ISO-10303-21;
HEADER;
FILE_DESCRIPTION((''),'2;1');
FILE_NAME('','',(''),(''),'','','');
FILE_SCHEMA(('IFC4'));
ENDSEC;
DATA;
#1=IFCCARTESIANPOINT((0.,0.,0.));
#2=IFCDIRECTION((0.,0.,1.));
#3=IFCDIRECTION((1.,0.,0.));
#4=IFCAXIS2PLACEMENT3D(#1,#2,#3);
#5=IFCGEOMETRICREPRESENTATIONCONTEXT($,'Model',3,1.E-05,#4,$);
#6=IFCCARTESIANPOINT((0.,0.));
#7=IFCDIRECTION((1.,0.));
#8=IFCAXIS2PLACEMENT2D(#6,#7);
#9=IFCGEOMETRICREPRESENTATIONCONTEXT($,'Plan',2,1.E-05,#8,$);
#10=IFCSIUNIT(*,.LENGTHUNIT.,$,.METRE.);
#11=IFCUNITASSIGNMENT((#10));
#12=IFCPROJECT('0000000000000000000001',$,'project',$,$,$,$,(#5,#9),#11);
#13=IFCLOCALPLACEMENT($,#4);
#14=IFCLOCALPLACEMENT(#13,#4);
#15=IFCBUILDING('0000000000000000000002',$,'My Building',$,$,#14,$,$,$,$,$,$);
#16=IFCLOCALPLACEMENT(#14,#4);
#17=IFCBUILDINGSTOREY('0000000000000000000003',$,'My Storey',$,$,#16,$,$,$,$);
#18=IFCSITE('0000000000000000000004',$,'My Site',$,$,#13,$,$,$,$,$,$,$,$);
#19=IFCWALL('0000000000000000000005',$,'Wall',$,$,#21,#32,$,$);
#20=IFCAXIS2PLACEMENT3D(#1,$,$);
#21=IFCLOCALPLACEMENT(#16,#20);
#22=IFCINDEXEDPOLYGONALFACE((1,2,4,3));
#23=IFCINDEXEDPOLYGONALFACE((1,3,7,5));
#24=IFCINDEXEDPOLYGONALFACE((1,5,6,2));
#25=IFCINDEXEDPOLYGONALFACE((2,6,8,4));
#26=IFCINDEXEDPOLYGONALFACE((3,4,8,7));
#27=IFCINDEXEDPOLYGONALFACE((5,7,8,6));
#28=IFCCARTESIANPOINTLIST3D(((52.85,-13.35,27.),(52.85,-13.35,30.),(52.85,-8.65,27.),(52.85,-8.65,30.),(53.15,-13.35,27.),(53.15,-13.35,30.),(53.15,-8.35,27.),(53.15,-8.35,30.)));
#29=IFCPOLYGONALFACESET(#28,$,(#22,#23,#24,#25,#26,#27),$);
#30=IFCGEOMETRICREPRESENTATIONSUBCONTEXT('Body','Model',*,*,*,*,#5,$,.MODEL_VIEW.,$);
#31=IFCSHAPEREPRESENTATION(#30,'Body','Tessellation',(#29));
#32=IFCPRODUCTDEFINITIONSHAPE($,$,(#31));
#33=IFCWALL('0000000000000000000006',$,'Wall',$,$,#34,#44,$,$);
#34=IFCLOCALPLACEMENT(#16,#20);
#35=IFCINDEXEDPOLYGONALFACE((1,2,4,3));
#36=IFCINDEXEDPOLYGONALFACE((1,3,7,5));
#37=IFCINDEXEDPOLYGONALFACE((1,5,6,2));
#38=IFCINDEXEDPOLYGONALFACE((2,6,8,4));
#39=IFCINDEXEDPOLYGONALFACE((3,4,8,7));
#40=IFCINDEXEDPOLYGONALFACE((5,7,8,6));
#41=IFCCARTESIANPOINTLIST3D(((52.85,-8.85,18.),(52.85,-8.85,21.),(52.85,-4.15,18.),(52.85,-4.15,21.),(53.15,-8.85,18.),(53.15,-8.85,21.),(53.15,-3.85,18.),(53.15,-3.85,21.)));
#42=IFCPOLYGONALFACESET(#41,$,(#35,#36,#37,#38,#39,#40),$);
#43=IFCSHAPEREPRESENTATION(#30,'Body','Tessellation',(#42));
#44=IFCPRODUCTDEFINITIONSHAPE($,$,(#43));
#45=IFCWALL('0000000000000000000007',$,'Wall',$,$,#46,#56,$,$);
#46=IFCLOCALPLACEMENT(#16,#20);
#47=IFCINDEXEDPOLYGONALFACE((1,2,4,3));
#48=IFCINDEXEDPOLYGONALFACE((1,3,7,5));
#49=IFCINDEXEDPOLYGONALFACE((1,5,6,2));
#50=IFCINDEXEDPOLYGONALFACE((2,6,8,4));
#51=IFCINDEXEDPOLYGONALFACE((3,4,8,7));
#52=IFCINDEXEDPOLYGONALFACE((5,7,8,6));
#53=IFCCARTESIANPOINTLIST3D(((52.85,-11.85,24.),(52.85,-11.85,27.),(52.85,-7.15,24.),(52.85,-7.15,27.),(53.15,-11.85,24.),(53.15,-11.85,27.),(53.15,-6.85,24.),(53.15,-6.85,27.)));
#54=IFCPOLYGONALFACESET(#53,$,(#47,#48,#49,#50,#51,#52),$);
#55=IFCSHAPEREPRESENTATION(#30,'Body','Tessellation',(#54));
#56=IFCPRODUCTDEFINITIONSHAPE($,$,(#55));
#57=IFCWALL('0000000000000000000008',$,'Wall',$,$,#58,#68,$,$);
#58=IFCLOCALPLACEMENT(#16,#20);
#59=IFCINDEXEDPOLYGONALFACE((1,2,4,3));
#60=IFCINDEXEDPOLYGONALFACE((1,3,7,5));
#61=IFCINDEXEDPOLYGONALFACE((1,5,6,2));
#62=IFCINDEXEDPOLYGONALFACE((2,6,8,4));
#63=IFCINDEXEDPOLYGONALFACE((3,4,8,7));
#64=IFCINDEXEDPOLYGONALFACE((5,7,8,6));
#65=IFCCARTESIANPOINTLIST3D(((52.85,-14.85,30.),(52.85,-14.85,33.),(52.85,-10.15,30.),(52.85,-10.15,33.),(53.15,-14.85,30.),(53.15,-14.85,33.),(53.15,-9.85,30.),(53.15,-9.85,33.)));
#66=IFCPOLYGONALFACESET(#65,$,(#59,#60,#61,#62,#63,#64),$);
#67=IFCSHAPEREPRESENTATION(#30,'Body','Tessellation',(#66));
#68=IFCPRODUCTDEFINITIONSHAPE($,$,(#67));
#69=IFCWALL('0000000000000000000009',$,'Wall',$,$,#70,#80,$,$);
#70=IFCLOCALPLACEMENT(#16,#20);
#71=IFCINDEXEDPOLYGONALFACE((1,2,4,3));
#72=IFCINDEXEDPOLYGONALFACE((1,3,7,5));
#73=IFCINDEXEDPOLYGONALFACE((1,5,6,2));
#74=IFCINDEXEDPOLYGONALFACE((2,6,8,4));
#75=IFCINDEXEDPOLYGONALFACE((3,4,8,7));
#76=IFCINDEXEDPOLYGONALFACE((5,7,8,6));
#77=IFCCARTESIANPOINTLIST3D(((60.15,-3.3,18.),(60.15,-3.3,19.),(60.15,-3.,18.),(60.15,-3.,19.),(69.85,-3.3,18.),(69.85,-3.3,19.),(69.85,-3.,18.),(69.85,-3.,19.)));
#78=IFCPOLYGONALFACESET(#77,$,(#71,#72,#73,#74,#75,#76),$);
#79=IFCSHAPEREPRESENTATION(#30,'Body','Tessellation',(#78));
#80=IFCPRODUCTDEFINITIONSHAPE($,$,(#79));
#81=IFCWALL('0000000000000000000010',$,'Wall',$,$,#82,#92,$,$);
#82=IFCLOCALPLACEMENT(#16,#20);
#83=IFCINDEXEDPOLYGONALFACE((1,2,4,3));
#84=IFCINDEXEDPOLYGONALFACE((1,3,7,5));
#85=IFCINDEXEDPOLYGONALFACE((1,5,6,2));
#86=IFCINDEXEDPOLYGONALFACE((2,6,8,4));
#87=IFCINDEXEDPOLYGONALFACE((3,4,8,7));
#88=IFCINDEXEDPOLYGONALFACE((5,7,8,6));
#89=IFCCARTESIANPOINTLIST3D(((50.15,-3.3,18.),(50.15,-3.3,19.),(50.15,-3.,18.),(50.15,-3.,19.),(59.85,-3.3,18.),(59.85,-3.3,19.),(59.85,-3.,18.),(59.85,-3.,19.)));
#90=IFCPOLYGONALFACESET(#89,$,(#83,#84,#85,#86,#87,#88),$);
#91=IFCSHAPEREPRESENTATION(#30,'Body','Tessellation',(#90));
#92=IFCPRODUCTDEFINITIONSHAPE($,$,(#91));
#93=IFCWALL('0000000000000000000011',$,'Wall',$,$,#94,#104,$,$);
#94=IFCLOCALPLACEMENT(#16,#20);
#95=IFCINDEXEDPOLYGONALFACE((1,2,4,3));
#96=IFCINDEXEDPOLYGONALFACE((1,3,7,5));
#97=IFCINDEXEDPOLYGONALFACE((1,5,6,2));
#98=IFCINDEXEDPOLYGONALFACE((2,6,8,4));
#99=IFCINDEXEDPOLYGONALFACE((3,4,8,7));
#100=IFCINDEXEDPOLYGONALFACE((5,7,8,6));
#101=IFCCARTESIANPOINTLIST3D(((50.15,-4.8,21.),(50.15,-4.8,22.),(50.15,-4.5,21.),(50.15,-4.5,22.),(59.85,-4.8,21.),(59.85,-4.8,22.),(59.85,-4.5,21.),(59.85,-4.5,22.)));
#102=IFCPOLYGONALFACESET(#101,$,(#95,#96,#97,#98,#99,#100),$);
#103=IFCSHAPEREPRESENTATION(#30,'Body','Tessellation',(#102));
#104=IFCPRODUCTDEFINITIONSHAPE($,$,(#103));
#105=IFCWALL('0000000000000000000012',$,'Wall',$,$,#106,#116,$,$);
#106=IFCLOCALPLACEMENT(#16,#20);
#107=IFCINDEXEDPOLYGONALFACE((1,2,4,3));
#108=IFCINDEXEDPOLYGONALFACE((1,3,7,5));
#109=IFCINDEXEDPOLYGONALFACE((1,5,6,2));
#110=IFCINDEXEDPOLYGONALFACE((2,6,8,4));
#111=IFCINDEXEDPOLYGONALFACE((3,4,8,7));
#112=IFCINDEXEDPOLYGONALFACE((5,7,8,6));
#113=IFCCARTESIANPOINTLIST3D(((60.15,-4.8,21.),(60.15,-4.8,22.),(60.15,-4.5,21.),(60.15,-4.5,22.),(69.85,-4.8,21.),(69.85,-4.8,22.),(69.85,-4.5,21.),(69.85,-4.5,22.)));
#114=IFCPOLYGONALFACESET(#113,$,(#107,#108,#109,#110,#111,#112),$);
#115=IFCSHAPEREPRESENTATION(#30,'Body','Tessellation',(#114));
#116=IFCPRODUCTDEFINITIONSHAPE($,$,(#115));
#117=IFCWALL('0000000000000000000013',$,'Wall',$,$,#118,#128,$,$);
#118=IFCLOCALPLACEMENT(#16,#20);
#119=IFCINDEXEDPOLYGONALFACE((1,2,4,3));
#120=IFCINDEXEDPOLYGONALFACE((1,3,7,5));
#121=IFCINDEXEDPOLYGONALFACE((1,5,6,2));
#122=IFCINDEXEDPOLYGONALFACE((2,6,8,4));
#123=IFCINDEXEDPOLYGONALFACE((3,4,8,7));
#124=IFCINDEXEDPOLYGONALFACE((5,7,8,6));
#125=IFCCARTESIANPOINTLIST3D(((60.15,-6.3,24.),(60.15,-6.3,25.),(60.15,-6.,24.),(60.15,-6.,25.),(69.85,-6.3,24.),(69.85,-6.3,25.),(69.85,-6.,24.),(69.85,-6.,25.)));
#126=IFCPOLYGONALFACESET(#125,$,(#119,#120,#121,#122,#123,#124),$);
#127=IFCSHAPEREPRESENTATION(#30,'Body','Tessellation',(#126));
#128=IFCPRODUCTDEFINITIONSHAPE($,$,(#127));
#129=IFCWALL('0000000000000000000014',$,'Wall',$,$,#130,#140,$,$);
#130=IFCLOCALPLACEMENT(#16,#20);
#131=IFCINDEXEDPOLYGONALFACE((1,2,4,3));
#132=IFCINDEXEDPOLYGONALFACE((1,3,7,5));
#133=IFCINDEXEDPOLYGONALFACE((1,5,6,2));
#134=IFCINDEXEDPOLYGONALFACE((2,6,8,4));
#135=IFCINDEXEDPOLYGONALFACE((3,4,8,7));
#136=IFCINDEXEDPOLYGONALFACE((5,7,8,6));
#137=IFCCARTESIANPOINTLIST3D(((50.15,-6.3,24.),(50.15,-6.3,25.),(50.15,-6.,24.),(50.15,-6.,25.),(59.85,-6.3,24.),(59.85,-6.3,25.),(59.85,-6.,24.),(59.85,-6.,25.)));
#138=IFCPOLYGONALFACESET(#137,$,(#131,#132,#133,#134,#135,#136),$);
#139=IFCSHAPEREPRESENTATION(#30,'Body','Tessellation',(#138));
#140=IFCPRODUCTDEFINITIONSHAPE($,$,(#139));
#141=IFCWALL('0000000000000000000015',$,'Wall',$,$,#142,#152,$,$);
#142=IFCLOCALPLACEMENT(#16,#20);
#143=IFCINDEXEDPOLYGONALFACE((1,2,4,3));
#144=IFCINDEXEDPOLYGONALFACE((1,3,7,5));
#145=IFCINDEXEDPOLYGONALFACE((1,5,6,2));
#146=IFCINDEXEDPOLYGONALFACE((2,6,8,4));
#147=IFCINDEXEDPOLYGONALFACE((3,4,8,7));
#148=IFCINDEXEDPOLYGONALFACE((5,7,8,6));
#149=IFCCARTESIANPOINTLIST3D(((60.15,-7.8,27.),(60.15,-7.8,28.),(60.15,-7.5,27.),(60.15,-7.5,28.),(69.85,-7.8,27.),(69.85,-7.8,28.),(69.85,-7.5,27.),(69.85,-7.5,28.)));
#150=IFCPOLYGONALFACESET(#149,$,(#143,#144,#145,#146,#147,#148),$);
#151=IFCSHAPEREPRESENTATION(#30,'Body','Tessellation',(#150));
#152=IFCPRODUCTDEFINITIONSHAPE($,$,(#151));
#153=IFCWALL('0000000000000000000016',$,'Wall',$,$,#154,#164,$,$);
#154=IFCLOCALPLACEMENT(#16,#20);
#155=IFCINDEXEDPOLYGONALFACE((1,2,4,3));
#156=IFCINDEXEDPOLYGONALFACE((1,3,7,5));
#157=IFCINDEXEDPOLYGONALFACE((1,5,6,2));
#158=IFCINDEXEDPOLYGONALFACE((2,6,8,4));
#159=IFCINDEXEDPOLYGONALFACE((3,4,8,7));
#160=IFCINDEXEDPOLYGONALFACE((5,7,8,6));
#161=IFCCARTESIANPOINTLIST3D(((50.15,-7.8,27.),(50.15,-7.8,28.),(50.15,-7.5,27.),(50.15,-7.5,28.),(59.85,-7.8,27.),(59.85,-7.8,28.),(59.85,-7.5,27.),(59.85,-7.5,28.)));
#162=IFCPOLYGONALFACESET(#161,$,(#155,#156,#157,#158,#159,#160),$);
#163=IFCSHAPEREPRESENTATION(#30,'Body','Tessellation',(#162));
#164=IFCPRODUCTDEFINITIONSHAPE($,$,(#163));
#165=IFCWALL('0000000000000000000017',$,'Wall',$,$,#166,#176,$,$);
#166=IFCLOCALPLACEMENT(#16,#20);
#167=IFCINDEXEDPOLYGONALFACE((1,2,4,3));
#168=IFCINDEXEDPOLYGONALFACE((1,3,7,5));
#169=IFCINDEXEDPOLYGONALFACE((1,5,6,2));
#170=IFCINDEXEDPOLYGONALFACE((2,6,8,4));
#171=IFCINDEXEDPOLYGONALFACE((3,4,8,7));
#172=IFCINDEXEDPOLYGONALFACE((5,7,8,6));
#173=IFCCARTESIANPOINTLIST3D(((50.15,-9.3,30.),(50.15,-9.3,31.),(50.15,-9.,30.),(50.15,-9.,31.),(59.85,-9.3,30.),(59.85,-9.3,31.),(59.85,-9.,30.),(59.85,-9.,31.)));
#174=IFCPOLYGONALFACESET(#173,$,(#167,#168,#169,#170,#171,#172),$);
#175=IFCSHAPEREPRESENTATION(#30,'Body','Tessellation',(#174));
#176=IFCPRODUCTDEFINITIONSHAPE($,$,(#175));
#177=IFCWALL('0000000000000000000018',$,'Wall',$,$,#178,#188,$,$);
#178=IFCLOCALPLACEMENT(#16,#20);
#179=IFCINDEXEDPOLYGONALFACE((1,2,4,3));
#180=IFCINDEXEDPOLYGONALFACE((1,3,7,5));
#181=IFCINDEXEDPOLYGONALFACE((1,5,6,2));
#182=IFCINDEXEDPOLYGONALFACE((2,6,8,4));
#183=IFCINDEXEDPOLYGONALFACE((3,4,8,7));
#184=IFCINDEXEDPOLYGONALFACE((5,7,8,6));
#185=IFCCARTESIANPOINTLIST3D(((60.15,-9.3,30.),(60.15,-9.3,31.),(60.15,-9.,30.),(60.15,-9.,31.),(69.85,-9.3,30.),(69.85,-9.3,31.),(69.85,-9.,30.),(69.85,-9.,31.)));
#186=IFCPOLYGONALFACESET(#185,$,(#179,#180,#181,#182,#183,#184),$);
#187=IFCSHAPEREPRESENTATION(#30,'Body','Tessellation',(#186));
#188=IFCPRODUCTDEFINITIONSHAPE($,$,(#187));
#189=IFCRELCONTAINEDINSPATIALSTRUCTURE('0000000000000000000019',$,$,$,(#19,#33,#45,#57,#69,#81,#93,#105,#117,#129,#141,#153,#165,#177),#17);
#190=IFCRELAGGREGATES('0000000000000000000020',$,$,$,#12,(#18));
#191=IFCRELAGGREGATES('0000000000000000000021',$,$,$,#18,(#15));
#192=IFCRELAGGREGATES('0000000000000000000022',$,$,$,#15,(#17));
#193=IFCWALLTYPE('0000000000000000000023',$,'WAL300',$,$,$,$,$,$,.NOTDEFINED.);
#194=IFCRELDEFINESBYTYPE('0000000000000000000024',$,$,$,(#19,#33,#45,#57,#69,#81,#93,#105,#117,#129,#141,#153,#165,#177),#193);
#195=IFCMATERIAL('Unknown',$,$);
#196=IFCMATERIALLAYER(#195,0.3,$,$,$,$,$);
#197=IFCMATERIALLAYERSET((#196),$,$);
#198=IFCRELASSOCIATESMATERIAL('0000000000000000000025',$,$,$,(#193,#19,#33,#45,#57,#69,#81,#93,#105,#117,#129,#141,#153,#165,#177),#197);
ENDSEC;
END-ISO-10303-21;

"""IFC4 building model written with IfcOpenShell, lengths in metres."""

from ifc_helpers import new_model, si_unit, frame, origin_with_axes, origin_2d_with_axis, place, context, subcontext, project, spatial, line, indexed_curve, outline, extrude, material, layer, layer_set, layer_usage, type_object, element, save


model = new_model("IFC4")

# Units and contexts
model_context = context("Model", 3, precision=1e-05, world=origin_with_axes())
plan_context = context("Plan", 2, precision=1e-05, world=origin_2d_with_axis())
body_context = subcontext(model_context, "Body", "Model", "MODEL_VIEW")
ifc_project = project(units=[si_unit("LENGTHUNIT", "METRE")], contexts=[model_context, plan_context])

# Site, building, storey
site_placement = place(None, origin_with_axes())
site = spatial("IfcSite", under=ifc_project, at=site_placement, Name="My Site")
building_placement = place(site_placement, origin_with_axes())
building = spatial("IfcBuilding", under=site, at=building_placement, Name="My Building")
storey_placement = place(building_placement, origin_with_axes())
storey = spatial("IfcBuildingStorey", under=building, at=storey_placement, Name="My Storey")

# Walls
ifc_material = material(Name="Unknown")
ifc_layer = layer(ifc_material, 0.3)
ifc_layer_set = layer_set([ifc_layer])
wall_type = type_object("IfcWallType", Name="WAL300", PredefinedType="NOTDEFINED", material=ifc_layer_set)
ifc_layer_usage_1 = layer_usage(ifc_layer_set, "AXIS2", "POSITIVE", -0.15)
wall_1_placement = place(storey_placement, frame((53.0, -13.5, 27.0), z_axis=(0.0, 0.0, 1.0), x_axis=(0.0, 1.0, 0.0)))
element("IfcWall", 1, at=wall_1_placement, inside=storey, type_object=wall_type, material=ifc_layer_usage_1, Name="Wall", context=body_context, shape_type="SweptSolid", body=[
    extrude(outline(indexed_curve([(0.15, -0.15), (0.15, 0.15), (4.85, 0.15), (5.15, -0.15)], segments=[line(1, 2, 3, 4, 1)])), origin_with_axes(), (0.0, 0.0, 1.0), 3.0),
])
ifc_layer_usage_2 = layer_usage(ifc_layer_set, "AXIS2", "POSITIVE", -0.15)
wall_2_placement = place(storey_placement, frame((53.0, -9.0, 18.0), z_axis=(0.0, 0.0, 1.0), x_axis=(0.0, 1.0, 0.0)))
element("IfcWall", 2, at=wall_2_placement, inside=storey, type_object=wall_type, material=ifc_layer_usage_2, Name="Wall", context=body_context, shape_type="SweptSolid", body=[
    extrude(outline(indexed_curve([(0.15, -0.15), (0.15, 0.15), (4.85, 0.15), (5.15, -0.15)], segments=[line(1, 2, 3, 4, 1)])), origin_with_axes(), (0.0, 0.0, 1.0), 3.0),
])
ifc_layer_usage_3 = layer_usage(ifc_layer_set, "AXIS2", "POSITIVE", -0.15)
wall_3_placement = place(storey_placement, frame((53.0, -12.0, 24.0), z_axis=(0.0, 0.0, 1.0), x_axis=(0.0, 1.0, 0.0)))
element("IfcWall", 3, at=wall_3_placement, inside=storey, type_object=wall_type, material=ifc_layer_usage_3, Name="Wall", context=body_context, shape_type="SweptSolid", body=[
    extrude(outline(indexed_curve([(0.15, -0.15), (0.15, 0.15), (4.85, 0.15), (5.15, -0.15)], segments=[line(1, 2, 3, 4, 1)])), origin_with_axes(), (0.0, 0.0, 1.0), 3.0),
])
ifc_layer_usage_4 = layer_usage(ifc_layer_set, "AXIS2", "POSITIVE", -0.15)
wall_4_placement = place(storey_placement, frame((53.0, -15.0, 30.0), z_axis=(0.0, 0.0, 1.0), x_axis=(0.0, 1.0, 0.0)))
element("IfcWall", 4, at=wall_4_placement, inside=storey, type_object=wall_type, material=ifc_layer_usage_4, Name="Wall", context=body_context, shape_type="SweptSolid", body=[
    extrude(outline(indexed_curve([(0.15, -0.15), (0.15, 0.15), (4.85, 0.15), (5.15, -0.15)], segments=[line(1, 2, 3, 4, 1)])), origin_with_axes(), (0.0, 0.0, 1.0), 3.0),
])
ifc_layer_usage_5 = layer_usage(ifc_layer_set, "AXIS2", "POSITIVE", -0.3)
wall_5_placement = place(storey_placement, frame((60.15, -3.0, 18.0), z_axis=(0.0, 0.0, 1.0), x_axis=(1.0, 0.0, 0.0)))
element("IfcWall", 5, at=wall_5_placement, inside=storey, type_object=wall_type, material=ifc_layer_usage_5, Name="Wall", context=body_context, shape_type="SweptSolid", body=[
    extrude(outline(indexed_curve([(0.0, -0.3), (0.0, 0.0), (9.7, 0.0), (9.7, -0.3)], segments=[line(1, 2, 3, 4, 1)])), origin_with_axes(), (0.0, 0.0, 1.0), 1.0),
])
ifc_layer_usage_6 = layer_usage(ifc_layer_set, "AXIS2", "POSITIVE", -0.3)
wall_6_placement = place(storey_placement, frame((50.15, -3.0, 18.0), z_axis=(0.0, 0.0, 1.0), x_axis=(1.0, 0.0, 0.0)))
element("IfcWall", 6, at=wall_6_placement, inside=storey, type_object=wall_type, material=ifc_layer_usage_6, Name="Wall", context=body_context, shape_type="SweptSolid", body=[
    extrude(outline(indexed_curve([(0.0, -0.3), (0.0, 0.0), (9.7, 0.0), (9.7, -0.3)], segments=[line(1, 2, 3, 4, 1)])), origin_with_axes(), (0.0, 0.0, 1.0), 1.0),
])
ifc_layer_usage_7 = layer_usage(ifc_layer_set, "AXIS2", "POSITIVE", -0.3)
wall_7_placement = place(storey_placement, frame((50.15, -4.5, 21.0), z_axis=(0.0, 0.0, 1.0), x_axis=(1.0, 0.0, 0.0)))
element("IfcWall", 7, at=wall_7_placement, inside=storey, type_object=wall_type, material=ifc_layer_usage_7, Name="Wall", context=body_context, shape_type="SweptSolid", body=[
    extrude(outline(indexed_curve([(0.0, -0.3), (0.0, 0.0), (9.7, 0.0), (9.7, -0.3)], segments=[line(1, 2, 3, 4, 1)])), origin_with_axes(), (0.0, 0.0, 1.0), 1.0),
])
ifc_layer_usage_8 = layer_usage(ifc_layer_set, "AXIS2", "POSITIVE", -0.3)
wall_8_placement = place(storey_placement, frame((60.15, -4.5, 21.0), z_axis=(0.0, 0.0, 1.0), x_axis=(1.0, 0.0, 0.0)))
element("IfcWall", 8, at=wall_8_placement, inside=storey, type_object=wall_type, material=ifc_layer_usage_8, Name="Wall", context=body_context, shape_type="SweptSolid", body=[
    extrude(outline(indexed_curve([(0.0, -0.3), (0.0, 0.0), (9.7, 0.0), (9.7, -0.3)], segments=[line(1, 2, 3, 4, 1)])), origin_with_axes(), (0.0, 0.0, 1.0), 1.0),
])
ifc_layer_usage_9 = layer_usage(ifc_layer_set, "AXIS2", "POSITIVE", -0.3)
wall_9_placement = place(storey_placement, frame((60.15, -6.0, 24.0), z_axis=(0.0, 0.0, 1.0), x_axis=(1.0, 0.0, 0.0)))
element("IfcWall", 9, at=wall_9_placement, inside=storey, type_object=wall_type, material=ifc_layer_usage_9, Name="Wall", context=body_context, shape_type="SweptSolid", body=[
    extrude(outline(indexed_curve([(0.0, -0.3), (0.0, 0.0), (9.7, 0.0), (9.7, -0.3)], segments=[line(1, 2, 3, 4, 1)])), origin_with_axes(), (0.0, 0.0, 1.0), 1.0),
])
ifc_layer_usage_10 = layer_usage(ifc_layer_set, "AXIS2", "POSITIVE", -0.3)
wall_10_placement = place(storey_placement, frame((50.15, -6.0, 24.0), z_axis=(0.0, 0.0, 1.0), x_axis=(1.0, 0.0, 0.0)))
element("IfcWall", 10, at=wall_10_placement, inside=storey, type_object=wall_type, material=ifc_layer_usage_10, Name="Wall", context=body_context, shape_type="SweptSolid", body=[
    extrude(outline(indexed_curve([(0.0, -0.3), (0.0, 0.0), (9.7, 0.0), (9.7, -0.3)], segments=[line(1, 2, 3, 4, 1)])), origin_with_axes(), (0.0, 0.0, 1.0), 1.0),
])
ifc_layer_usage_11 = layer_usage(ifc_layer_set, "AXIS2", "POSITIVE", -0.3)
wall_11_placement = place(storey_placement, frame((60.15, -7.5, 27.0), z_axis=(0.0, 0.0, 1.0), x_axis=(1.0, 0.0, 0.0)))
element("IfcWall", 11, at=wall_11_placement, inside=storey, type_object=wall_type, material=ifc_layer_usage_11, Name="Wall", context=body_context, shape_type="SweptSolid", body=[
    extrude(outline(indexed_curve([(0.0, -0.3), (0.0, 0.0), (9.7, 0.0), (9.7, -0.3)], segments=[line(1, 2, 3, 4, 1)])), origin_with_axes(), (0.0, 0.0, 1.0), 1.0),
])
ifc_layer_usage_12 = layer_usage(ifc_layer_set, "AXIS2", "POSITIVE", -0.3)
wall_12_placement = place(storey_placement, frame((50.15, -7.5, 27.0), z_axis=(0.0, 0.0, 1.0), x_axis=(1.0, 0.0, 0.0)))
element("IfcWall", 12, at=wall_12_placement, inside=storey, type_object=wall_type, material=ifc_layer_usage_12, Name="Wall", context=body_context, shape_type="SweptSolid", body=[
    extrude(outline(indexed_curve([(0.0, -0.3), (0.0, 0.0), (9.7, 0.0), (9.7, -0.3)], segments=[line(1, 2, 3, 4, 1)])), origin_with_axes(), (0.0, 0.0, 1.0), 1.0),
])
ifc_layer_usage_13 = layer_usage(ifc_layer_set, "AXIS2", "POSITIVE", -0.3)
wall_13_placement = place(storey_placement, frame((50.15, -9.0, 30.0), z_axis=(0.0, 0.0, 1.0), x_axis=(1.0, 0.0, 0.0)))
element("IfcWall", 13, at=wall_13_placement, inside=storey, type_object=wall_type, material=ifc_layer_usage_13, Name="Wall", context=body_context, shape_type="SweptSolid", body=[
    extrude(outline(indexed_curve([(0.0, -0.3), (0.0, 0.0), (9.7, 0.0), (9.7, -0.3)], segments=[line(1, 2, 3, 4, 1)])), origin_with_axes(), (0.0, 0.0, 1.0), 1.0),
])
ifc_layer_usage_14 = layer_usage(ifc_layer_set, "AXIS2", "POSITIVE", -0.3)
wall_14_placement = place(storey_placement, frame((60.15, -9.0, 30.0), z_axis=(0.0, 0.0, 1.0), x_axis=(1.0, 0.0, 0.0)))
element("IfcWall", 14, at=wall_14_placement, inside=storey, type_object=wall_type, material=ifc_layer_usage_14, Name="Wall", context=body_context, shape_type="SweptSolid", body=[
    extrude(outline(indexed_curve([(0.0, -0.3), (0.0, 0.0), (9.7, 0.0), (9.7, -0.3)], segments=[line(1, 2, 3, 4, 1)])), origin_with_axes(), (0.0, 0.0, 1.0), 1.0),
])

save(model, "model.ifc")
